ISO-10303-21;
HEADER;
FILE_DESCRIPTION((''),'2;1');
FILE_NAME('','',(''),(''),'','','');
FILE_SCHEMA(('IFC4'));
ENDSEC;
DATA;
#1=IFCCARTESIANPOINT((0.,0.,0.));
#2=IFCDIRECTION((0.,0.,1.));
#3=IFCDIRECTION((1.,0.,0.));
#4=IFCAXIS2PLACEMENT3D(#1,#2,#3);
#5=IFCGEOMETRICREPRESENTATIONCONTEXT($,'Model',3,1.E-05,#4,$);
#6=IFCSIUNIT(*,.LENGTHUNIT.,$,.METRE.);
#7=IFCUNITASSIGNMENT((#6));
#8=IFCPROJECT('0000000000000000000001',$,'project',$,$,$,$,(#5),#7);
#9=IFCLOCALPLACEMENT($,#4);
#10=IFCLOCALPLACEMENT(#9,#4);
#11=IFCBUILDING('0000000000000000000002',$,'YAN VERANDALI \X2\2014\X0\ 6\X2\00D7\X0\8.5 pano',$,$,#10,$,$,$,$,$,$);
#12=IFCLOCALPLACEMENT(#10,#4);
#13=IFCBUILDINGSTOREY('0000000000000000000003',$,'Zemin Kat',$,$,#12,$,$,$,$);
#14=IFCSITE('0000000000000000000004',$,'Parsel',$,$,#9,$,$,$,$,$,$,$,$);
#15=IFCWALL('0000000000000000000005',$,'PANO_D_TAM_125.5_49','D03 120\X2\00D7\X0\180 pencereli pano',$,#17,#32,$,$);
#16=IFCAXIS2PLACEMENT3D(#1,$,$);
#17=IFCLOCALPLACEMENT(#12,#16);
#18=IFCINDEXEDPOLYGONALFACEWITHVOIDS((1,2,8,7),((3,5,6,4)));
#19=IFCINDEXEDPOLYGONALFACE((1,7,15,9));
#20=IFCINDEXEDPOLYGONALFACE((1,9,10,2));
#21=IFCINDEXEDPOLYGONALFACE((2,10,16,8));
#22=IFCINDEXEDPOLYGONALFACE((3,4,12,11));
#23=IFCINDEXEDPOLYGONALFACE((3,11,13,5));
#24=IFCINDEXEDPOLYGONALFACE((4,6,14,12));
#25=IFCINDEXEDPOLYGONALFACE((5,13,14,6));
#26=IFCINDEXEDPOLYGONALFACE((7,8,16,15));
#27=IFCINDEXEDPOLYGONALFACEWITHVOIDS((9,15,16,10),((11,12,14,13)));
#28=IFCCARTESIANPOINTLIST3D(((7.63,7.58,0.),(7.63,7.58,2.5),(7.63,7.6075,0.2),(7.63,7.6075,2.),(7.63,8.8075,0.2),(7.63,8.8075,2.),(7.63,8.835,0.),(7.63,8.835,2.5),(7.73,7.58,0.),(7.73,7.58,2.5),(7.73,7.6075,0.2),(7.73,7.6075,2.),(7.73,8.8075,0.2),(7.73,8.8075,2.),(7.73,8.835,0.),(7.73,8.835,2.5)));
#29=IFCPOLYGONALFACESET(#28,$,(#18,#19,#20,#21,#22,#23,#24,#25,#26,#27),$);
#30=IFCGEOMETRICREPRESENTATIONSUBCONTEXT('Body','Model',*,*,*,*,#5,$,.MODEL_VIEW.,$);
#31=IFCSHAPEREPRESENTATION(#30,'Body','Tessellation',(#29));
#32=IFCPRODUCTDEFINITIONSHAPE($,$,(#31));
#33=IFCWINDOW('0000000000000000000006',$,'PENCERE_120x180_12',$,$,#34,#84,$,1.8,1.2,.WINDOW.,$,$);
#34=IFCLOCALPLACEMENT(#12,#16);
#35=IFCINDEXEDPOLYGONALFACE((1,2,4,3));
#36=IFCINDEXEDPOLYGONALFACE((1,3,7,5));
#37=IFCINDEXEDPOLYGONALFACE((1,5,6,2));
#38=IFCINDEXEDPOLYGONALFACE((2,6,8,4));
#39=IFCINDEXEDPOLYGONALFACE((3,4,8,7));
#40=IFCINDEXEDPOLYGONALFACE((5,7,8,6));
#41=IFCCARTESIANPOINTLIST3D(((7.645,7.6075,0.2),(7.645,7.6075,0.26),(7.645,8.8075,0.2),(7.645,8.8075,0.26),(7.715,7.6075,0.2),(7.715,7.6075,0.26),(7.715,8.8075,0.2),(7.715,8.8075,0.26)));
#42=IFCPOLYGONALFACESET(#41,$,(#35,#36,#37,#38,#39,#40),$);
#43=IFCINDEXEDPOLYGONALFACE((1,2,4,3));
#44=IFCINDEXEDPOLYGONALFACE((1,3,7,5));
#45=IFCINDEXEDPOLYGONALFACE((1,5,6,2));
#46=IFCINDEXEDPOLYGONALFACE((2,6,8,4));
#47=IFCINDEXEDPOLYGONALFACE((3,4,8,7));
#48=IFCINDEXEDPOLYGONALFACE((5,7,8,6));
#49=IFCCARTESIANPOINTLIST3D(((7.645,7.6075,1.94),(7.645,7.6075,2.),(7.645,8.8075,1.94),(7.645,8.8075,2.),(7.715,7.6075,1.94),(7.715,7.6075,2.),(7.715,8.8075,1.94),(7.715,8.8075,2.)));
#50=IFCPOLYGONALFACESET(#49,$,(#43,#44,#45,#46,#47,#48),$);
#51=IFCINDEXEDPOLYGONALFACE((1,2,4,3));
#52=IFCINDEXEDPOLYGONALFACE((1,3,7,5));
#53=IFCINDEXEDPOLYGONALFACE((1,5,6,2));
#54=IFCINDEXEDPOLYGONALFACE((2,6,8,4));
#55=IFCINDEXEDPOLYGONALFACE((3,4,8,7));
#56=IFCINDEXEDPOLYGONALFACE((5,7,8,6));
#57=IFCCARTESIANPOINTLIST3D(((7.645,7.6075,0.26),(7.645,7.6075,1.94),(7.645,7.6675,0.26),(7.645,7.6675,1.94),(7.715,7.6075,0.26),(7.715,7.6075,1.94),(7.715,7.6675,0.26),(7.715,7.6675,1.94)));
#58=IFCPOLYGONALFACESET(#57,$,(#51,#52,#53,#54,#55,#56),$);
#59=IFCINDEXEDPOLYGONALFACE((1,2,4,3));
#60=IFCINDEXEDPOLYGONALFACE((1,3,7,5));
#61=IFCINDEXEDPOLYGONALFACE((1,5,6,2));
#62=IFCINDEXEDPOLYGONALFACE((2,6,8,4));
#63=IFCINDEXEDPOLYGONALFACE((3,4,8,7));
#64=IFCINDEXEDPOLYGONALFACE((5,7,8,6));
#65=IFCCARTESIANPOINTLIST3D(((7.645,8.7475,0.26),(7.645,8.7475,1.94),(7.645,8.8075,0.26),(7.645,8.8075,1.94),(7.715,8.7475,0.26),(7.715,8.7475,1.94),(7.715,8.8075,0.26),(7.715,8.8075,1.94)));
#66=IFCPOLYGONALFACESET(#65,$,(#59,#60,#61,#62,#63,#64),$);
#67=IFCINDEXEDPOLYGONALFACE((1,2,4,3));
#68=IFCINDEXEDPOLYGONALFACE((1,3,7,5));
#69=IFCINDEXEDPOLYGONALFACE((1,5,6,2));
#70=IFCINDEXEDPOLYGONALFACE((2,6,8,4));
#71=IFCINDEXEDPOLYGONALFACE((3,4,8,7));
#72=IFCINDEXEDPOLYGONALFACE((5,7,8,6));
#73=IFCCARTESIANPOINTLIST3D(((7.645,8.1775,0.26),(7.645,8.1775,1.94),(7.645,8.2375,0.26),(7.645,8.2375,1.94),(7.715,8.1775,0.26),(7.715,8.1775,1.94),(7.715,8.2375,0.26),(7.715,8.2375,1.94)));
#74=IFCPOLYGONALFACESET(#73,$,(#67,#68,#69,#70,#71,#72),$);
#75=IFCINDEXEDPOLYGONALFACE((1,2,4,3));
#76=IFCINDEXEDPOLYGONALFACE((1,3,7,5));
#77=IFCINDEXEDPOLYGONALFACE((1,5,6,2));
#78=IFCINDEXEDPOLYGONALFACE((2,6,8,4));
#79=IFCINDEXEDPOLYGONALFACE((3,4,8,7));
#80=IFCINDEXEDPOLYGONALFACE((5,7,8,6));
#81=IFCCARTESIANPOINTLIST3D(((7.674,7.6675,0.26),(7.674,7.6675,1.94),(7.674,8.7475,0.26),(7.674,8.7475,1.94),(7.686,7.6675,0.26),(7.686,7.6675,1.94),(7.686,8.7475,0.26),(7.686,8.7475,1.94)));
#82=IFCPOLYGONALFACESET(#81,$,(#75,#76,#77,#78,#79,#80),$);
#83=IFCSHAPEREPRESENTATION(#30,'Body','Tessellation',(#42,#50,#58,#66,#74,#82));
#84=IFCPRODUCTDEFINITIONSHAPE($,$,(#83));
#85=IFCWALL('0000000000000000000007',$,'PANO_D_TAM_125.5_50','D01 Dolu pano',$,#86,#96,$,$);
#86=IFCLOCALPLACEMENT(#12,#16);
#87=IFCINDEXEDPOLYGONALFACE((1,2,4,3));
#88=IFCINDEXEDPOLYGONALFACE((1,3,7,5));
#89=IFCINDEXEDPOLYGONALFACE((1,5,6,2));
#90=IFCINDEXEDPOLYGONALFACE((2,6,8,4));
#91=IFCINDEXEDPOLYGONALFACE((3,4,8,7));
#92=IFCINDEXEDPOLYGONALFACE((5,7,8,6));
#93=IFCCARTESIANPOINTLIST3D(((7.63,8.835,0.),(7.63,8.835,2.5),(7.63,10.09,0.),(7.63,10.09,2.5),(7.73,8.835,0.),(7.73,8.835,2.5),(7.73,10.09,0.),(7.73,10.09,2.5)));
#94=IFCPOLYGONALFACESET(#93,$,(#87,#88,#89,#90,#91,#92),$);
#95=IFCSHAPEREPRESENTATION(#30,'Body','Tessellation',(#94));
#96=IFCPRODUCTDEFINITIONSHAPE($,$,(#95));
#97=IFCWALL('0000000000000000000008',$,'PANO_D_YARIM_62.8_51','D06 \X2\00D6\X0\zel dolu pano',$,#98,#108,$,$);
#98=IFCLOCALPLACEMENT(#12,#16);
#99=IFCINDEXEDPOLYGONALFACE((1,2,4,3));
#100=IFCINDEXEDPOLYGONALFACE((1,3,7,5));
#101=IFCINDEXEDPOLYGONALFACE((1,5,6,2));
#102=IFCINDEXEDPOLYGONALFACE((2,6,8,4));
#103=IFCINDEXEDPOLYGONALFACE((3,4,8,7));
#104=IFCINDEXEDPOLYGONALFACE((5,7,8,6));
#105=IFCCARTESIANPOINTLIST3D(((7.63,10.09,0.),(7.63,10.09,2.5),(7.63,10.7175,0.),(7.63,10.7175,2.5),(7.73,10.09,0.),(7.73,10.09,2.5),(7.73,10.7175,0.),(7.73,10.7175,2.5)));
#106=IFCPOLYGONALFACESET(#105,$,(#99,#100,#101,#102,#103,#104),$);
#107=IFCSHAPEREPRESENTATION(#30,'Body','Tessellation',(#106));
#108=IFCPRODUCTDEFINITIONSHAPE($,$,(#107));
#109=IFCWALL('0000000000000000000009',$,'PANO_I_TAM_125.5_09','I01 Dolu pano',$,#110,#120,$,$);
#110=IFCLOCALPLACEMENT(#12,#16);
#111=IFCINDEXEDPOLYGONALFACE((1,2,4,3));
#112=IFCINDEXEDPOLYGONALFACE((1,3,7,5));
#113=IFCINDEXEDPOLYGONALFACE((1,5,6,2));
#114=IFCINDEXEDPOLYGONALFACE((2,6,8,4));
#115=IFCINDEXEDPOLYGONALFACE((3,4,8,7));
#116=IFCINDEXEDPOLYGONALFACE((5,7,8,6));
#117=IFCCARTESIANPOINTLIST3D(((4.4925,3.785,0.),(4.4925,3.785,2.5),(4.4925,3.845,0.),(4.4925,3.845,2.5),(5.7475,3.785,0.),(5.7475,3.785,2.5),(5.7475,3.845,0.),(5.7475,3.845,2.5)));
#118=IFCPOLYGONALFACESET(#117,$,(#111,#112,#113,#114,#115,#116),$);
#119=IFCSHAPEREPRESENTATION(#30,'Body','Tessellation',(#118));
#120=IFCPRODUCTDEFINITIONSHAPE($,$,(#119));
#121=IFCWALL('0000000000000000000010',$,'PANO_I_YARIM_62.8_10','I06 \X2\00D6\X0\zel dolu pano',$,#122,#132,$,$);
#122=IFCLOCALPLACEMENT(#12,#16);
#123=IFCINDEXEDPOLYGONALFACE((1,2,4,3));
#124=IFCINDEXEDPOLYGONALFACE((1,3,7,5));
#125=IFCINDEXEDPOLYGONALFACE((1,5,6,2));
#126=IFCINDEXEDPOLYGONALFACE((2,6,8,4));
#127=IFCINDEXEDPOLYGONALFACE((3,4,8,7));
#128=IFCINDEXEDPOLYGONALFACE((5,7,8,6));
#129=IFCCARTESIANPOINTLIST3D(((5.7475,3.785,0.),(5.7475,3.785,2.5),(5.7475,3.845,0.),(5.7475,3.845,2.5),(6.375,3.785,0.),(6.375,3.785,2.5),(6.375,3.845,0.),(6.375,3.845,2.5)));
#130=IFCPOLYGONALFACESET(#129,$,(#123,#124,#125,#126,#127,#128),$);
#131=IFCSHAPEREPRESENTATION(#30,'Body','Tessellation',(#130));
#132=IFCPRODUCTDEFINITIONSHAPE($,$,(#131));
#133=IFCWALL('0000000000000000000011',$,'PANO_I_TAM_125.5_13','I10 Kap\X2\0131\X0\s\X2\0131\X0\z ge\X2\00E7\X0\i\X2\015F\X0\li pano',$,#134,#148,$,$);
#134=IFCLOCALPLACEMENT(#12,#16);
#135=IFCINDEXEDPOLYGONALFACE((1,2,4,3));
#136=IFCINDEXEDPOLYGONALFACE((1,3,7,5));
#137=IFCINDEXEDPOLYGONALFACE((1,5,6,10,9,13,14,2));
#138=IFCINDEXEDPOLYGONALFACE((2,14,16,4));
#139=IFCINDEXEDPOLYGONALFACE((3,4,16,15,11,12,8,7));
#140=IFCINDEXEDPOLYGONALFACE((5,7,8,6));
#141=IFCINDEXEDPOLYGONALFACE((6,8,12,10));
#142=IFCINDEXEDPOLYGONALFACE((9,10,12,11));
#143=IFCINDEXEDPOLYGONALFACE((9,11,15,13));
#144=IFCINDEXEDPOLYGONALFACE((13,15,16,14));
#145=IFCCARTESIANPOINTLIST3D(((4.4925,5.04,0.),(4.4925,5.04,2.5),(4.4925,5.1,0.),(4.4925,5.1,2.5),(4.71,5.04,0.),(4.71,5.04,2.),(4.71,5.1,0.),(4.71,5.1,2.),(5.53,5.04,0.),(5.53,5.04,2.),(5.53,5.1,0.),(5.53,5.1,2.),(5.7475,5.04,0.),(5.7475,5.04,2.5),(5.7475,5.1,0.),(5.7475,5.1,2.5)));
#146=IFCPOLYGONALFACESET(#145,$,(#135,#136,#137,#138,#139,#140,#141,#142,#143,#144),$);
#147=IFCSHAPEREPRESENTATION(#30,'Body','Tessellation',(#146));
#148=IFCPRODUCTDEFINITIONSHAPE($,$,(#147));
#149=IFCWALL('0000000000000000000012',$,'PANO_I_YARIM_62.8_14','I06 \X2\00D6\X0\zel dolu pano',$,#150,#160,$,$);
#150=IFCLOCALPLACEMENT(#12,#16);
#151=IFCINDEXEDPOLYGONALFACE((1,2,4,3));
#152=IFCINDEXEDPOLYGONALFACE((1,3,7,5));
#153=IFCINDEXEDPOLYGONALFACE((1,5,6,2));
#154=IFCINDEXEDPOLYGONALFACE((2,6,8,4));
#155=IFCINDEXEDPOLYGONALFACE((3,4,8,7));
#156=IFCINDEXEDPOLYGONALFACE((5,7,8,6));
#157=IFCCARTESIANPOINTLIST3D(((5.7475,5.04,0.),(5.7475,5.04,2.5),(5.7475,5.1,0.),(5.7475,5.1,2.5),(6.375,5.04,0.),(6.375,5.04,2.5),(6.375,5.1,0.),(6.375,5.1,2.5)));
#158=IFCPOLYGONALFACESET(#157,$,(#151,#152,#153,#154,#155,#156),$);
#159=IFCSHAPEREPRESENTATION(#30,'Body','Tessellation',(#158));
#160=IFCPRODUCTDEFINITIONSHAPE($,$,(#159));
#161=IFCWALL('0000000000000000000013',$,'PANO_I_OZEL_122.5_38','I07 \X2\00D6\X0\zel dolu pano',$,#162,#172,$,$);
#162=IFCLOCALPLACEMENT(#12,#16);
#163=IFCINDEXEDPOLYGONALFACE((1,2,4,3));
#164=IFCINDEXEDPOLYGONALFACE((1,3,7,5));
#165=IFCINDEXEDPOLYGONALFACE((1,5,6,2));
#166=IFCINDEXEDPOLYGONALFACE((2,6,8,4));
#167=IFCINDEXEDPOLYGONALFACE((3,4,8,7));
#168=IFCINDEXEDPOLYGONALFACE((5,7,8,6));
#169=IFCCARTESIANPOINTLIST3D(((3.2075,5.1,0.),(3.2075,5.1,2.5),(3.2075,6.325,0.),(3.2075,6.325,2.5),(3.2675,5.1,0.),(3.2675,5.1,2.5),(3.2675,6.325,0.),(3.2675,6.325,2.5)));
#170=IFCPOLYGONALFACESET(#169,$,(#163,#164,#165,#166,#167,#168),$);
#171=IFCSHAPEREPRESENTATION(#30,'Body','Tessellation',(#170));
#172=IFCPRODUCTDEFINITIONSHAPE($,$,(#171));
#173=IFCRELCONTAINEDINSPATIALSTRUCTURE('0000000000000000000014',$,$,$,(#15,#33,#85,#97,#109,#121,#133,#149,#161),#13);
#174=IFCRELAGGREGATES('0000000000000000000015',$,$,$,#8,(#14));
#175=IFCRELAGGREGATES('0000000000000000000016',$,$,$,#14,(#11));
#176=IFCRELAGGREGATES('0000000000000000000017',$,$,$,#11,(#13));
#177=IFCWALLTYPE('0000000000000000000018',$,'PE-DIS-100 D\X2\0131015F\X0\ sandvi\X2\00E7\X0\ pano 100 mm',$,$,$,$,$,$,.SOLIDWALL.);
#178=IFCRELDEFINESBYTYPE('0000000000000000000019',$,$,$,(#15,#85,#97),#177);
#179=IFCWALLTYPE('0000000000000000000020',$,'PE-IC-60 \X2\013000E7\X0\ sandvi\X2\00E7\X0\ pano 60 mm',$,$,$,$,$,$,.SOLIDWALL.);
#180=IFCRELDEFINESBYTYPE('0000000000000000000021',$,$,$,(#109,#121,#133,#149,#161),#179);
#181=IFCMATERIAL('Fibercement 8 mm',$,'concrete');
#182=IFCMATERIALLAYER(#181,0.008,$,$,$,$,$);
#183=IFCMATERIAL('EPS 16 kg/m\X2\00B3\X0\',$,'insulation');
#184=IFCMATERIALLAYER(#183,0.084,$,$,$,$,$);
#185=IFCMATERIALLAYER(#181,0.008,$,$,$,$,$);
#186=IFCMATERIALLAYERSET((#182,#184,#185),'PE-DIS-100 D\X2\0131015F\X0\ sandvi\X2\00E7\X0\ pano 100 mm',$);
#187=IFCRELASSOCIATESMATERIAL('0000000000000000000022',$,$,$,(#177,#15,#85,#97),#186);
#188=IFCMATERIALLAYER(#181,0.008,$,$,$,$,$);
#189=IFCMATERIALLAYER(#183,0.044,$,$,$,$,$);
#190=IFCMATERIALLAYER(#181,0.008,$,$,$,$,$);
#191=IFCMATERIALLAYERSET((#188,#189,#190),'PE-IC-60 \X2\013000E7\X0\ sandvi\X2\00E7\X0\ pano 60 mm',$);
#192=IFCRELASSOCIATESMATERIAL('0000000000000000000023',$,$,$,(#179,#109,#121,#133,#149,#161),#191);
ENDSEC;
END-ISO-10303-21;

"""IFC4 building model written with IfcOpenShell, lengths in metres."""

from ifc_helpers import new_model, si_unit, frame, origin_with_axes, place, context, subcontext, project, spatial, line, indexed_curve, outline, extrude, material, layer, layer_set, layer_usage, type_object, element, fill, save


model = new_model("IFC4")

# Units and contexts
model_context = context("Model", 3, precision=1e-05, world=origin_with_axes())
body_context = subcontext(model_context, "Body", "Model", "MODEL_VIEW")
ifc_project = project(units=[si_unit("LENGTHUNIT", "METRE")], contexts=[model_context])

# Site, building, storey
site_placement = place(None, origin_with_axes())
site = spatial("IfcSite", under=ifc_project, at=site_placement, Name="Parsel")
building_placement = place(site_placement, origin_with_axes())
building = spatial("IfcBuilding", under=site, at=building_placement, Name="YAN VERANDALI — 6×8.5 pano")
storey_placement = place(building_placement, origin_with_axes())
storey = spatial("IfcBuildingStorey", under=building, at=storey_placement, Name="Zemin Kat")

# Shared definitions
ifc_material_1 = material(Name="Fibercement 8 mm", Category="concrete")
ifc_layer_1 = layer(ifc_material_1, 0.008)
ifc_material_2 = material(Name="EPS 16 kg/m³", Category="insulation")
ifc_layer_2 = layer(ifc_material_2, 0.084)
ifc_layer_3 = layer(ifc_material_1, 0.008)
ifc_layer_set_1 = layer_set([ifc_layer_1, ifc_layer_2, ifc_layer_3], Name="PE-DIS-100 Dış sandviç pano 100 mm")
wall_type_1 = type_object("IfcWallType", Name="PE-DIS-100 Dış sandviç pano 100 mm", PredefinedType="SOLIDWALL", material=ifc_layer_set_1)

# Wall, opening, window
ifc_layer_usage_1 = layer_usage(ifc_layer_set_1, "AXIS2", "POSITIVE", 0.0)
wall_1_placement = place(storey_placement, frame((7.73, 7.58, 0.0), z_axis=(0.0, 0.0, 1.0), x_axis=(0.0, 1.0, 0.0)))
wall_1 = element("IfcWall", 1, at=wall_1_placement, inside=storey, type_object=wall_type_1, material=ifc_layer_usage_1, Name="PANO_D_TAM_125.5_49", Description="D03 120×180 pencereli pano", context=body_context, shape_type="SweptSolid", body=[
    extrude(outline(indexed_curve([(0.0, 0.0), (1.255, 0.0), (1.255, 0.1), (0.0, 0.1)], segments=[line(1, 2, 3, 4, 1)])), origin_with_axes(), (0.0, 0.0, 1.0), 2.5),
])
opening_1_placement = place(wall_1_placement, origin_with_axes())
opening_1 = element("IfcOpeningElement", 2, at=opening_1_placement, cuts=wall_1, PredefinedType="OPENING", context=body_context, shape_type="SweptSolid", body=[
    extrude(outline(indexed_curve([(0.0, 0.0), (1.2, 0.0), (1.2, 0.14), (0.0, 0.14)], segments=[line(1, 2, 3, 4, 1)])), frame((0.0275, -0.02, 0.2), z_axis=(0.0, 0.0, 1.0), x_axis=(1.0, 0.0, 0.0)), (0.0, 0.0, 1.0), 1.8),
])
window_1_placement = place(storey_placement, frame((7.73, 7.58, 0.0), z_axis=(0.0, 0.0, 1.0), x_axis=(0.0, 1.0, 0.0)))
window_1 = element("IfcWindow", 3, at=window_1_placement, inside=storey, Name="PENCERE_120x180_12", OverallHeight=1.8, OverallWidth=1.2, PredefinedType="WINDOW", context=body_context, shape_type="SweptSolid", body=[
    extrude(outline(indexed_curve([(0.0, 0.0), (1.2, 0.0), (1.2, 0.07), (0.0, 0.07)], segments=[line(1, 2, 3, 4, 1)])), frame((0.0275, 0.015, 0.2), z_axis=(0.0, 0.0, 1.0), x_axis=(1.0, 0.0, 0.0)), (0.0, 0.0, 1.0), 0.06),
    extrude(outline(indexed_curve([(0.0, 0.0), (1.2, 0.0), (1.2, 0.07), (0.0, 0.07)], segments=[line(1, 2, 3, 4, 1)])), frame((0.0275, 0.015, 1.94), z_axis=(0.0, 0.0, 1.0), x_axis=(1.0, 0.0, 0.0)), (0.0, 0.0, 1.0), 0.06),
    extrude(outline(indexed_curve([(0.0, 0.0), (0.06, 0.0), (0.06, 0.07), (0.0, 0.07)], segments=[line(1, 2, 3, 4, 1)])), frame((0.0275, 0.015, 0.26), z_axis=(0.0, 0.0, 1.0), x_axis=(1.0, 0.0, 0.0)), (0.0, 0.0, 1.0), 1.68),
    extrude(outline(indexed_curve([(0.0, 0.0), (0.06, 0.0), (0.06, 0.07), (0.0, 0.07)], segments=[line(1, 2, 3, 4, 1)])), frame((1.1675, 0.015, 0.26), z_axis=(0.0, 0.0, 1.0), x_axis=(1.0, 0.0, 0.0)), (0.0, 0.0, 1.0), 1.68),
    extrude(outline(indexed_curve([(0.0, 0.0), (0.06, 0.0), (0.06, 0.07), (0.0, 0.07)], segments=[line(1, 2, 3, 4, 1)])), frame((0.5975, 0.015, 0.26), z_axis=(0.0, 0.0, 1.0), x_axis=(1.0, 0.0, 0.0)), (0.0, 0.0, 1.0), 1.68),
    extrude(outline(indexed_curve([(0.0, 0.0), (1.08, 0.0), (1.08, 0.012), (0.0, 0.012)], segments=[line(1, 2, 3, 4, 1)])), frame((0.0875, 0.044, 0.26), z_axis=(0.0, 0.0, 1.0), x_axis=(1.0, 0.0, 0.0)), (0.0, 0.0, 1.0), 1.68),
])
fill(opening_1, window_1)

# Walls
ifc_layer_usage_2 = layer_usage(ifc_layer_set_1, "AXIS2", "POSITIVE", 0.0)
wall_2_placement = place(storey_placement, frame((7.73, 8.835, 0.0), z_axis=(0.0, 0.0, 1.0), x_axis=(0.0, 1.0, 0.0)))
element("IfcWall", 4, at=wall_2_placement, inside=storey, type_object=wall_type_1, material=ifc_layer_usage_2, Name="PANO_D_TAM_125.5_50", Description="D01 Dolu pano", context=body_context, shape_type="SweptSolid", body=[
    extrude(outline(indexed_curve([(0.0, 0.0), (1.255, 0.0), (1.255, 0.1), (0.0, 0.1)], segments=[line(1, 2, 3, 4, 1)])), origin_with_axes(), (0.0, 0.0, 1.0), 2.5),
])
ifc_layer_usage_3 = layer_usage(ifc_layer_set_1, "AXIS2", "POSITIVE", 0.0)
wall_3_placement = place(storey_placement, frame((7.73, 10.09, 0.0), z_axis=(0.0, 0.0, 1.0), x_axis=(0.0, 1.0, 0.0)))
element("IfcWall", 5, at=wall_3_placement, inside=storey, type_object=wall_type_1, material=ifc_layer_usage_3, Name="PANO_D_YARIM_62.8_51", Description="D06 Özel dolu pano", context=body_context, shape_type="SweptSolid", body=[
    extrude(outline(indexed_curve([(0.0, 0.0), (0.6275, 0.0), (0.6275, 0.1), (0.0, 0.1)], segments=[line(1, 2, 3, 4, 1)])), origin_with_axes(), (0.0, 0.0, 1.0), 2.5),
])
ifc_layer_4 = layer(ifc_material_1, 0.008)
ifc_layer_5 = layer(ifc_material_2, 0.044)
ifc_layer_6 = layer(ifc_material_1, 0.008)
ifc_layer_set_2 = layer_set([ifc_layer_4, ifc_layer_5, ifc_layer_6], Name="PE-IC-60 İç sandviç pano 60 mm")
ifc_layer_usage_4 = layer_usage(ifc_layer_set_2, "AXIS2", "POSITIVE", 0.0)
wall_type_2 = type_object("IfcWallType", Name="PE-IC-60 İç sandviç pano 60 mm", PredefinedType="SOLIDWALL", material=ifc_layer_set_2)
wall_4_placement = place(storey_placement, frame((4.4925, 3.785, 0.0), z_axis=(0.0, 0.0, 1.0), x_axis=(1.0, 0.0, 0.0)))
element("IfcWall", 6, at=wall_4_placement, inside=storey, type_object=wall_type_2, material=ifc_layer_usage_4, Name="PANO_I_TAM_125.5_09", Description="I01 Dolu pano", context=body_context, shape_type="SweptSolid", body=[
    extrude(outline(indexed_curve([(0.0, 0.0), (1.255, 0.0), (1.255, 0.06), (0.0, 0.06)], segments=[line(1, 2, 3, 4, 1)])), origin_with_axes(), (0.0, 0.0, 1.0), 2.5),
])
ifc_layer_usage_5 = layer_usage(ifc_layer_set_2, "AXIS2", "POSITIVE", 0.0)
wall_5_placement = place(storey_placement, frame((5.7475, 3.785, 0.0), z_axis=(0.0, 0.0, 1.0), x_axis=(1.0, 0.0, 0.0)))
element("IfcWall", 7, at=wall_5_placement, inside=storey, type_object=wall_type_2, material=ifc_layer_usage_5, Name="PANO_I_YARIM_62.8_10", Description="I06 Özel dolu pano", context=body_context, shape_type="SweptSolid", body=[
    extrude(outline(indexed_curve([(0.0, 0.0), (0.6275, 0.0), (0.6275, 0.06), (0.0, 0.06)], segments=[line(1, 2, 3, 4, 1)])), origin_with_axes(), (0.0, 0.0, 1.0), 2.5),
])

# Wall, opening
ifc_layer_usage_6 = layer_usage(ifc_layer_set_2, "AXIS2", "POSITIVE", 0.0)
wall_6_placement = place(storey_placement, frame((4.4925, 5.04, 0.0), z_axis=(0.0, 0.0, 1.0), x_axis=(1.0, 0.0, 0.0)))
wall_6 = element("IfcWall", 8, at=wall_6_placement, inside=storey, type_object=wall_type_2, material=ifc_layer_usage_6, Name="PANO_I_TAM_125.5_13", Description="I10 Kapısız geçişli pano", context=body_context, shape_type="SweptSolid", body=[
    extrude(outline(indexed_curve([(0.0, 0.0), (1.255, 0.0), (1.255, 0.06), (0.0, 0.06)], segments=[line(1, 2, 3, 4, 1)])), origin_with_axes(), (0.0, 0.0, 1.0), 2.5),
])
opening_2_placement = place(wall_6_placement, origin_with_axes())
element("IfcOpeningElement", 9, at=opening_2_placement, cuts=wall_6, PredefinedType="OPENING", context=body_context, shape_type="SweptSolid", body=[
    extrude(outline(indexed_curve([(0.0, 0.0), (0.82, 0.0), (0.82, 0.1), (0.0, 0.1)], segments=[line(1, 2, 3, 4, 1)])), frame((0.2175, -0.02, 0.0), z_axis=(0.0, 0.0, 1.0), x_axis=(1.0, 0.0, 0.0)), (0.0, 0.0, 1.0), 2.0),
])

# Walls
ifc_layer_usage_7 = layer_usage(ifc_layer_set_2, "AXIS2", "POSITIVE", 0.0)
wall_7_placement = place(storey_placement, frame((5.7475, 5.04, 0.0), z_axis=(0.0, 0.0, 1.0), x_axis=(1.0, 0.0, 0.0)))
element("IfcWall", 10, at=wall_7_placement, inside=storey, type_object=wall_type_2, material=ifc_layer_usage_7, Name="PANO_I_YARIM_62.8_14", Description="I06 Özel dolu pano", context=body_context, shape_type="SweptSolid", body=[
    extrude(outline(indexed_curve([(0.0, 0.0), (0.6275, 0.0), (0.6275, 0.06), (0.0, 0.06)], segments=[line(1, 2, 3, 4, 1)])), origin_with_axes(), (0.0, 0.0, 1.0), 2.5),
])
ifc_layer_usage_8 = layer_usage(ifc_layer_set_2, "AXIS2", "POSITIVE", 0.0)
wall_8_placement = place(storey_placement, frame((3.2675, 5.1, 0.0), z_axis=(0.0, 0.0, 1.0), x_axis=(0.0, 1.0, 0.0)))
element("IfcWall", 11, at=wall_8_placement, inside=storey, type_object=wall_type_2, material=ifc_layer_usage_8, Name="PANO_I_OZEL_122.5_38", Description="I07 Özel dolu pano", context=body_context, shape_type="SweptSolid", body=[
    extrude(outline(indexed_curve([(0.0, 0.0), (1.225, 0.0), (1.225, 0.06), (0.0, 0.06)], segments=[line(1, 2, 3, 4, 1)])), origin_with_axes(), (0.0, 0.0, 1.0), 2.5),
])

save(model, "model.ifc")
